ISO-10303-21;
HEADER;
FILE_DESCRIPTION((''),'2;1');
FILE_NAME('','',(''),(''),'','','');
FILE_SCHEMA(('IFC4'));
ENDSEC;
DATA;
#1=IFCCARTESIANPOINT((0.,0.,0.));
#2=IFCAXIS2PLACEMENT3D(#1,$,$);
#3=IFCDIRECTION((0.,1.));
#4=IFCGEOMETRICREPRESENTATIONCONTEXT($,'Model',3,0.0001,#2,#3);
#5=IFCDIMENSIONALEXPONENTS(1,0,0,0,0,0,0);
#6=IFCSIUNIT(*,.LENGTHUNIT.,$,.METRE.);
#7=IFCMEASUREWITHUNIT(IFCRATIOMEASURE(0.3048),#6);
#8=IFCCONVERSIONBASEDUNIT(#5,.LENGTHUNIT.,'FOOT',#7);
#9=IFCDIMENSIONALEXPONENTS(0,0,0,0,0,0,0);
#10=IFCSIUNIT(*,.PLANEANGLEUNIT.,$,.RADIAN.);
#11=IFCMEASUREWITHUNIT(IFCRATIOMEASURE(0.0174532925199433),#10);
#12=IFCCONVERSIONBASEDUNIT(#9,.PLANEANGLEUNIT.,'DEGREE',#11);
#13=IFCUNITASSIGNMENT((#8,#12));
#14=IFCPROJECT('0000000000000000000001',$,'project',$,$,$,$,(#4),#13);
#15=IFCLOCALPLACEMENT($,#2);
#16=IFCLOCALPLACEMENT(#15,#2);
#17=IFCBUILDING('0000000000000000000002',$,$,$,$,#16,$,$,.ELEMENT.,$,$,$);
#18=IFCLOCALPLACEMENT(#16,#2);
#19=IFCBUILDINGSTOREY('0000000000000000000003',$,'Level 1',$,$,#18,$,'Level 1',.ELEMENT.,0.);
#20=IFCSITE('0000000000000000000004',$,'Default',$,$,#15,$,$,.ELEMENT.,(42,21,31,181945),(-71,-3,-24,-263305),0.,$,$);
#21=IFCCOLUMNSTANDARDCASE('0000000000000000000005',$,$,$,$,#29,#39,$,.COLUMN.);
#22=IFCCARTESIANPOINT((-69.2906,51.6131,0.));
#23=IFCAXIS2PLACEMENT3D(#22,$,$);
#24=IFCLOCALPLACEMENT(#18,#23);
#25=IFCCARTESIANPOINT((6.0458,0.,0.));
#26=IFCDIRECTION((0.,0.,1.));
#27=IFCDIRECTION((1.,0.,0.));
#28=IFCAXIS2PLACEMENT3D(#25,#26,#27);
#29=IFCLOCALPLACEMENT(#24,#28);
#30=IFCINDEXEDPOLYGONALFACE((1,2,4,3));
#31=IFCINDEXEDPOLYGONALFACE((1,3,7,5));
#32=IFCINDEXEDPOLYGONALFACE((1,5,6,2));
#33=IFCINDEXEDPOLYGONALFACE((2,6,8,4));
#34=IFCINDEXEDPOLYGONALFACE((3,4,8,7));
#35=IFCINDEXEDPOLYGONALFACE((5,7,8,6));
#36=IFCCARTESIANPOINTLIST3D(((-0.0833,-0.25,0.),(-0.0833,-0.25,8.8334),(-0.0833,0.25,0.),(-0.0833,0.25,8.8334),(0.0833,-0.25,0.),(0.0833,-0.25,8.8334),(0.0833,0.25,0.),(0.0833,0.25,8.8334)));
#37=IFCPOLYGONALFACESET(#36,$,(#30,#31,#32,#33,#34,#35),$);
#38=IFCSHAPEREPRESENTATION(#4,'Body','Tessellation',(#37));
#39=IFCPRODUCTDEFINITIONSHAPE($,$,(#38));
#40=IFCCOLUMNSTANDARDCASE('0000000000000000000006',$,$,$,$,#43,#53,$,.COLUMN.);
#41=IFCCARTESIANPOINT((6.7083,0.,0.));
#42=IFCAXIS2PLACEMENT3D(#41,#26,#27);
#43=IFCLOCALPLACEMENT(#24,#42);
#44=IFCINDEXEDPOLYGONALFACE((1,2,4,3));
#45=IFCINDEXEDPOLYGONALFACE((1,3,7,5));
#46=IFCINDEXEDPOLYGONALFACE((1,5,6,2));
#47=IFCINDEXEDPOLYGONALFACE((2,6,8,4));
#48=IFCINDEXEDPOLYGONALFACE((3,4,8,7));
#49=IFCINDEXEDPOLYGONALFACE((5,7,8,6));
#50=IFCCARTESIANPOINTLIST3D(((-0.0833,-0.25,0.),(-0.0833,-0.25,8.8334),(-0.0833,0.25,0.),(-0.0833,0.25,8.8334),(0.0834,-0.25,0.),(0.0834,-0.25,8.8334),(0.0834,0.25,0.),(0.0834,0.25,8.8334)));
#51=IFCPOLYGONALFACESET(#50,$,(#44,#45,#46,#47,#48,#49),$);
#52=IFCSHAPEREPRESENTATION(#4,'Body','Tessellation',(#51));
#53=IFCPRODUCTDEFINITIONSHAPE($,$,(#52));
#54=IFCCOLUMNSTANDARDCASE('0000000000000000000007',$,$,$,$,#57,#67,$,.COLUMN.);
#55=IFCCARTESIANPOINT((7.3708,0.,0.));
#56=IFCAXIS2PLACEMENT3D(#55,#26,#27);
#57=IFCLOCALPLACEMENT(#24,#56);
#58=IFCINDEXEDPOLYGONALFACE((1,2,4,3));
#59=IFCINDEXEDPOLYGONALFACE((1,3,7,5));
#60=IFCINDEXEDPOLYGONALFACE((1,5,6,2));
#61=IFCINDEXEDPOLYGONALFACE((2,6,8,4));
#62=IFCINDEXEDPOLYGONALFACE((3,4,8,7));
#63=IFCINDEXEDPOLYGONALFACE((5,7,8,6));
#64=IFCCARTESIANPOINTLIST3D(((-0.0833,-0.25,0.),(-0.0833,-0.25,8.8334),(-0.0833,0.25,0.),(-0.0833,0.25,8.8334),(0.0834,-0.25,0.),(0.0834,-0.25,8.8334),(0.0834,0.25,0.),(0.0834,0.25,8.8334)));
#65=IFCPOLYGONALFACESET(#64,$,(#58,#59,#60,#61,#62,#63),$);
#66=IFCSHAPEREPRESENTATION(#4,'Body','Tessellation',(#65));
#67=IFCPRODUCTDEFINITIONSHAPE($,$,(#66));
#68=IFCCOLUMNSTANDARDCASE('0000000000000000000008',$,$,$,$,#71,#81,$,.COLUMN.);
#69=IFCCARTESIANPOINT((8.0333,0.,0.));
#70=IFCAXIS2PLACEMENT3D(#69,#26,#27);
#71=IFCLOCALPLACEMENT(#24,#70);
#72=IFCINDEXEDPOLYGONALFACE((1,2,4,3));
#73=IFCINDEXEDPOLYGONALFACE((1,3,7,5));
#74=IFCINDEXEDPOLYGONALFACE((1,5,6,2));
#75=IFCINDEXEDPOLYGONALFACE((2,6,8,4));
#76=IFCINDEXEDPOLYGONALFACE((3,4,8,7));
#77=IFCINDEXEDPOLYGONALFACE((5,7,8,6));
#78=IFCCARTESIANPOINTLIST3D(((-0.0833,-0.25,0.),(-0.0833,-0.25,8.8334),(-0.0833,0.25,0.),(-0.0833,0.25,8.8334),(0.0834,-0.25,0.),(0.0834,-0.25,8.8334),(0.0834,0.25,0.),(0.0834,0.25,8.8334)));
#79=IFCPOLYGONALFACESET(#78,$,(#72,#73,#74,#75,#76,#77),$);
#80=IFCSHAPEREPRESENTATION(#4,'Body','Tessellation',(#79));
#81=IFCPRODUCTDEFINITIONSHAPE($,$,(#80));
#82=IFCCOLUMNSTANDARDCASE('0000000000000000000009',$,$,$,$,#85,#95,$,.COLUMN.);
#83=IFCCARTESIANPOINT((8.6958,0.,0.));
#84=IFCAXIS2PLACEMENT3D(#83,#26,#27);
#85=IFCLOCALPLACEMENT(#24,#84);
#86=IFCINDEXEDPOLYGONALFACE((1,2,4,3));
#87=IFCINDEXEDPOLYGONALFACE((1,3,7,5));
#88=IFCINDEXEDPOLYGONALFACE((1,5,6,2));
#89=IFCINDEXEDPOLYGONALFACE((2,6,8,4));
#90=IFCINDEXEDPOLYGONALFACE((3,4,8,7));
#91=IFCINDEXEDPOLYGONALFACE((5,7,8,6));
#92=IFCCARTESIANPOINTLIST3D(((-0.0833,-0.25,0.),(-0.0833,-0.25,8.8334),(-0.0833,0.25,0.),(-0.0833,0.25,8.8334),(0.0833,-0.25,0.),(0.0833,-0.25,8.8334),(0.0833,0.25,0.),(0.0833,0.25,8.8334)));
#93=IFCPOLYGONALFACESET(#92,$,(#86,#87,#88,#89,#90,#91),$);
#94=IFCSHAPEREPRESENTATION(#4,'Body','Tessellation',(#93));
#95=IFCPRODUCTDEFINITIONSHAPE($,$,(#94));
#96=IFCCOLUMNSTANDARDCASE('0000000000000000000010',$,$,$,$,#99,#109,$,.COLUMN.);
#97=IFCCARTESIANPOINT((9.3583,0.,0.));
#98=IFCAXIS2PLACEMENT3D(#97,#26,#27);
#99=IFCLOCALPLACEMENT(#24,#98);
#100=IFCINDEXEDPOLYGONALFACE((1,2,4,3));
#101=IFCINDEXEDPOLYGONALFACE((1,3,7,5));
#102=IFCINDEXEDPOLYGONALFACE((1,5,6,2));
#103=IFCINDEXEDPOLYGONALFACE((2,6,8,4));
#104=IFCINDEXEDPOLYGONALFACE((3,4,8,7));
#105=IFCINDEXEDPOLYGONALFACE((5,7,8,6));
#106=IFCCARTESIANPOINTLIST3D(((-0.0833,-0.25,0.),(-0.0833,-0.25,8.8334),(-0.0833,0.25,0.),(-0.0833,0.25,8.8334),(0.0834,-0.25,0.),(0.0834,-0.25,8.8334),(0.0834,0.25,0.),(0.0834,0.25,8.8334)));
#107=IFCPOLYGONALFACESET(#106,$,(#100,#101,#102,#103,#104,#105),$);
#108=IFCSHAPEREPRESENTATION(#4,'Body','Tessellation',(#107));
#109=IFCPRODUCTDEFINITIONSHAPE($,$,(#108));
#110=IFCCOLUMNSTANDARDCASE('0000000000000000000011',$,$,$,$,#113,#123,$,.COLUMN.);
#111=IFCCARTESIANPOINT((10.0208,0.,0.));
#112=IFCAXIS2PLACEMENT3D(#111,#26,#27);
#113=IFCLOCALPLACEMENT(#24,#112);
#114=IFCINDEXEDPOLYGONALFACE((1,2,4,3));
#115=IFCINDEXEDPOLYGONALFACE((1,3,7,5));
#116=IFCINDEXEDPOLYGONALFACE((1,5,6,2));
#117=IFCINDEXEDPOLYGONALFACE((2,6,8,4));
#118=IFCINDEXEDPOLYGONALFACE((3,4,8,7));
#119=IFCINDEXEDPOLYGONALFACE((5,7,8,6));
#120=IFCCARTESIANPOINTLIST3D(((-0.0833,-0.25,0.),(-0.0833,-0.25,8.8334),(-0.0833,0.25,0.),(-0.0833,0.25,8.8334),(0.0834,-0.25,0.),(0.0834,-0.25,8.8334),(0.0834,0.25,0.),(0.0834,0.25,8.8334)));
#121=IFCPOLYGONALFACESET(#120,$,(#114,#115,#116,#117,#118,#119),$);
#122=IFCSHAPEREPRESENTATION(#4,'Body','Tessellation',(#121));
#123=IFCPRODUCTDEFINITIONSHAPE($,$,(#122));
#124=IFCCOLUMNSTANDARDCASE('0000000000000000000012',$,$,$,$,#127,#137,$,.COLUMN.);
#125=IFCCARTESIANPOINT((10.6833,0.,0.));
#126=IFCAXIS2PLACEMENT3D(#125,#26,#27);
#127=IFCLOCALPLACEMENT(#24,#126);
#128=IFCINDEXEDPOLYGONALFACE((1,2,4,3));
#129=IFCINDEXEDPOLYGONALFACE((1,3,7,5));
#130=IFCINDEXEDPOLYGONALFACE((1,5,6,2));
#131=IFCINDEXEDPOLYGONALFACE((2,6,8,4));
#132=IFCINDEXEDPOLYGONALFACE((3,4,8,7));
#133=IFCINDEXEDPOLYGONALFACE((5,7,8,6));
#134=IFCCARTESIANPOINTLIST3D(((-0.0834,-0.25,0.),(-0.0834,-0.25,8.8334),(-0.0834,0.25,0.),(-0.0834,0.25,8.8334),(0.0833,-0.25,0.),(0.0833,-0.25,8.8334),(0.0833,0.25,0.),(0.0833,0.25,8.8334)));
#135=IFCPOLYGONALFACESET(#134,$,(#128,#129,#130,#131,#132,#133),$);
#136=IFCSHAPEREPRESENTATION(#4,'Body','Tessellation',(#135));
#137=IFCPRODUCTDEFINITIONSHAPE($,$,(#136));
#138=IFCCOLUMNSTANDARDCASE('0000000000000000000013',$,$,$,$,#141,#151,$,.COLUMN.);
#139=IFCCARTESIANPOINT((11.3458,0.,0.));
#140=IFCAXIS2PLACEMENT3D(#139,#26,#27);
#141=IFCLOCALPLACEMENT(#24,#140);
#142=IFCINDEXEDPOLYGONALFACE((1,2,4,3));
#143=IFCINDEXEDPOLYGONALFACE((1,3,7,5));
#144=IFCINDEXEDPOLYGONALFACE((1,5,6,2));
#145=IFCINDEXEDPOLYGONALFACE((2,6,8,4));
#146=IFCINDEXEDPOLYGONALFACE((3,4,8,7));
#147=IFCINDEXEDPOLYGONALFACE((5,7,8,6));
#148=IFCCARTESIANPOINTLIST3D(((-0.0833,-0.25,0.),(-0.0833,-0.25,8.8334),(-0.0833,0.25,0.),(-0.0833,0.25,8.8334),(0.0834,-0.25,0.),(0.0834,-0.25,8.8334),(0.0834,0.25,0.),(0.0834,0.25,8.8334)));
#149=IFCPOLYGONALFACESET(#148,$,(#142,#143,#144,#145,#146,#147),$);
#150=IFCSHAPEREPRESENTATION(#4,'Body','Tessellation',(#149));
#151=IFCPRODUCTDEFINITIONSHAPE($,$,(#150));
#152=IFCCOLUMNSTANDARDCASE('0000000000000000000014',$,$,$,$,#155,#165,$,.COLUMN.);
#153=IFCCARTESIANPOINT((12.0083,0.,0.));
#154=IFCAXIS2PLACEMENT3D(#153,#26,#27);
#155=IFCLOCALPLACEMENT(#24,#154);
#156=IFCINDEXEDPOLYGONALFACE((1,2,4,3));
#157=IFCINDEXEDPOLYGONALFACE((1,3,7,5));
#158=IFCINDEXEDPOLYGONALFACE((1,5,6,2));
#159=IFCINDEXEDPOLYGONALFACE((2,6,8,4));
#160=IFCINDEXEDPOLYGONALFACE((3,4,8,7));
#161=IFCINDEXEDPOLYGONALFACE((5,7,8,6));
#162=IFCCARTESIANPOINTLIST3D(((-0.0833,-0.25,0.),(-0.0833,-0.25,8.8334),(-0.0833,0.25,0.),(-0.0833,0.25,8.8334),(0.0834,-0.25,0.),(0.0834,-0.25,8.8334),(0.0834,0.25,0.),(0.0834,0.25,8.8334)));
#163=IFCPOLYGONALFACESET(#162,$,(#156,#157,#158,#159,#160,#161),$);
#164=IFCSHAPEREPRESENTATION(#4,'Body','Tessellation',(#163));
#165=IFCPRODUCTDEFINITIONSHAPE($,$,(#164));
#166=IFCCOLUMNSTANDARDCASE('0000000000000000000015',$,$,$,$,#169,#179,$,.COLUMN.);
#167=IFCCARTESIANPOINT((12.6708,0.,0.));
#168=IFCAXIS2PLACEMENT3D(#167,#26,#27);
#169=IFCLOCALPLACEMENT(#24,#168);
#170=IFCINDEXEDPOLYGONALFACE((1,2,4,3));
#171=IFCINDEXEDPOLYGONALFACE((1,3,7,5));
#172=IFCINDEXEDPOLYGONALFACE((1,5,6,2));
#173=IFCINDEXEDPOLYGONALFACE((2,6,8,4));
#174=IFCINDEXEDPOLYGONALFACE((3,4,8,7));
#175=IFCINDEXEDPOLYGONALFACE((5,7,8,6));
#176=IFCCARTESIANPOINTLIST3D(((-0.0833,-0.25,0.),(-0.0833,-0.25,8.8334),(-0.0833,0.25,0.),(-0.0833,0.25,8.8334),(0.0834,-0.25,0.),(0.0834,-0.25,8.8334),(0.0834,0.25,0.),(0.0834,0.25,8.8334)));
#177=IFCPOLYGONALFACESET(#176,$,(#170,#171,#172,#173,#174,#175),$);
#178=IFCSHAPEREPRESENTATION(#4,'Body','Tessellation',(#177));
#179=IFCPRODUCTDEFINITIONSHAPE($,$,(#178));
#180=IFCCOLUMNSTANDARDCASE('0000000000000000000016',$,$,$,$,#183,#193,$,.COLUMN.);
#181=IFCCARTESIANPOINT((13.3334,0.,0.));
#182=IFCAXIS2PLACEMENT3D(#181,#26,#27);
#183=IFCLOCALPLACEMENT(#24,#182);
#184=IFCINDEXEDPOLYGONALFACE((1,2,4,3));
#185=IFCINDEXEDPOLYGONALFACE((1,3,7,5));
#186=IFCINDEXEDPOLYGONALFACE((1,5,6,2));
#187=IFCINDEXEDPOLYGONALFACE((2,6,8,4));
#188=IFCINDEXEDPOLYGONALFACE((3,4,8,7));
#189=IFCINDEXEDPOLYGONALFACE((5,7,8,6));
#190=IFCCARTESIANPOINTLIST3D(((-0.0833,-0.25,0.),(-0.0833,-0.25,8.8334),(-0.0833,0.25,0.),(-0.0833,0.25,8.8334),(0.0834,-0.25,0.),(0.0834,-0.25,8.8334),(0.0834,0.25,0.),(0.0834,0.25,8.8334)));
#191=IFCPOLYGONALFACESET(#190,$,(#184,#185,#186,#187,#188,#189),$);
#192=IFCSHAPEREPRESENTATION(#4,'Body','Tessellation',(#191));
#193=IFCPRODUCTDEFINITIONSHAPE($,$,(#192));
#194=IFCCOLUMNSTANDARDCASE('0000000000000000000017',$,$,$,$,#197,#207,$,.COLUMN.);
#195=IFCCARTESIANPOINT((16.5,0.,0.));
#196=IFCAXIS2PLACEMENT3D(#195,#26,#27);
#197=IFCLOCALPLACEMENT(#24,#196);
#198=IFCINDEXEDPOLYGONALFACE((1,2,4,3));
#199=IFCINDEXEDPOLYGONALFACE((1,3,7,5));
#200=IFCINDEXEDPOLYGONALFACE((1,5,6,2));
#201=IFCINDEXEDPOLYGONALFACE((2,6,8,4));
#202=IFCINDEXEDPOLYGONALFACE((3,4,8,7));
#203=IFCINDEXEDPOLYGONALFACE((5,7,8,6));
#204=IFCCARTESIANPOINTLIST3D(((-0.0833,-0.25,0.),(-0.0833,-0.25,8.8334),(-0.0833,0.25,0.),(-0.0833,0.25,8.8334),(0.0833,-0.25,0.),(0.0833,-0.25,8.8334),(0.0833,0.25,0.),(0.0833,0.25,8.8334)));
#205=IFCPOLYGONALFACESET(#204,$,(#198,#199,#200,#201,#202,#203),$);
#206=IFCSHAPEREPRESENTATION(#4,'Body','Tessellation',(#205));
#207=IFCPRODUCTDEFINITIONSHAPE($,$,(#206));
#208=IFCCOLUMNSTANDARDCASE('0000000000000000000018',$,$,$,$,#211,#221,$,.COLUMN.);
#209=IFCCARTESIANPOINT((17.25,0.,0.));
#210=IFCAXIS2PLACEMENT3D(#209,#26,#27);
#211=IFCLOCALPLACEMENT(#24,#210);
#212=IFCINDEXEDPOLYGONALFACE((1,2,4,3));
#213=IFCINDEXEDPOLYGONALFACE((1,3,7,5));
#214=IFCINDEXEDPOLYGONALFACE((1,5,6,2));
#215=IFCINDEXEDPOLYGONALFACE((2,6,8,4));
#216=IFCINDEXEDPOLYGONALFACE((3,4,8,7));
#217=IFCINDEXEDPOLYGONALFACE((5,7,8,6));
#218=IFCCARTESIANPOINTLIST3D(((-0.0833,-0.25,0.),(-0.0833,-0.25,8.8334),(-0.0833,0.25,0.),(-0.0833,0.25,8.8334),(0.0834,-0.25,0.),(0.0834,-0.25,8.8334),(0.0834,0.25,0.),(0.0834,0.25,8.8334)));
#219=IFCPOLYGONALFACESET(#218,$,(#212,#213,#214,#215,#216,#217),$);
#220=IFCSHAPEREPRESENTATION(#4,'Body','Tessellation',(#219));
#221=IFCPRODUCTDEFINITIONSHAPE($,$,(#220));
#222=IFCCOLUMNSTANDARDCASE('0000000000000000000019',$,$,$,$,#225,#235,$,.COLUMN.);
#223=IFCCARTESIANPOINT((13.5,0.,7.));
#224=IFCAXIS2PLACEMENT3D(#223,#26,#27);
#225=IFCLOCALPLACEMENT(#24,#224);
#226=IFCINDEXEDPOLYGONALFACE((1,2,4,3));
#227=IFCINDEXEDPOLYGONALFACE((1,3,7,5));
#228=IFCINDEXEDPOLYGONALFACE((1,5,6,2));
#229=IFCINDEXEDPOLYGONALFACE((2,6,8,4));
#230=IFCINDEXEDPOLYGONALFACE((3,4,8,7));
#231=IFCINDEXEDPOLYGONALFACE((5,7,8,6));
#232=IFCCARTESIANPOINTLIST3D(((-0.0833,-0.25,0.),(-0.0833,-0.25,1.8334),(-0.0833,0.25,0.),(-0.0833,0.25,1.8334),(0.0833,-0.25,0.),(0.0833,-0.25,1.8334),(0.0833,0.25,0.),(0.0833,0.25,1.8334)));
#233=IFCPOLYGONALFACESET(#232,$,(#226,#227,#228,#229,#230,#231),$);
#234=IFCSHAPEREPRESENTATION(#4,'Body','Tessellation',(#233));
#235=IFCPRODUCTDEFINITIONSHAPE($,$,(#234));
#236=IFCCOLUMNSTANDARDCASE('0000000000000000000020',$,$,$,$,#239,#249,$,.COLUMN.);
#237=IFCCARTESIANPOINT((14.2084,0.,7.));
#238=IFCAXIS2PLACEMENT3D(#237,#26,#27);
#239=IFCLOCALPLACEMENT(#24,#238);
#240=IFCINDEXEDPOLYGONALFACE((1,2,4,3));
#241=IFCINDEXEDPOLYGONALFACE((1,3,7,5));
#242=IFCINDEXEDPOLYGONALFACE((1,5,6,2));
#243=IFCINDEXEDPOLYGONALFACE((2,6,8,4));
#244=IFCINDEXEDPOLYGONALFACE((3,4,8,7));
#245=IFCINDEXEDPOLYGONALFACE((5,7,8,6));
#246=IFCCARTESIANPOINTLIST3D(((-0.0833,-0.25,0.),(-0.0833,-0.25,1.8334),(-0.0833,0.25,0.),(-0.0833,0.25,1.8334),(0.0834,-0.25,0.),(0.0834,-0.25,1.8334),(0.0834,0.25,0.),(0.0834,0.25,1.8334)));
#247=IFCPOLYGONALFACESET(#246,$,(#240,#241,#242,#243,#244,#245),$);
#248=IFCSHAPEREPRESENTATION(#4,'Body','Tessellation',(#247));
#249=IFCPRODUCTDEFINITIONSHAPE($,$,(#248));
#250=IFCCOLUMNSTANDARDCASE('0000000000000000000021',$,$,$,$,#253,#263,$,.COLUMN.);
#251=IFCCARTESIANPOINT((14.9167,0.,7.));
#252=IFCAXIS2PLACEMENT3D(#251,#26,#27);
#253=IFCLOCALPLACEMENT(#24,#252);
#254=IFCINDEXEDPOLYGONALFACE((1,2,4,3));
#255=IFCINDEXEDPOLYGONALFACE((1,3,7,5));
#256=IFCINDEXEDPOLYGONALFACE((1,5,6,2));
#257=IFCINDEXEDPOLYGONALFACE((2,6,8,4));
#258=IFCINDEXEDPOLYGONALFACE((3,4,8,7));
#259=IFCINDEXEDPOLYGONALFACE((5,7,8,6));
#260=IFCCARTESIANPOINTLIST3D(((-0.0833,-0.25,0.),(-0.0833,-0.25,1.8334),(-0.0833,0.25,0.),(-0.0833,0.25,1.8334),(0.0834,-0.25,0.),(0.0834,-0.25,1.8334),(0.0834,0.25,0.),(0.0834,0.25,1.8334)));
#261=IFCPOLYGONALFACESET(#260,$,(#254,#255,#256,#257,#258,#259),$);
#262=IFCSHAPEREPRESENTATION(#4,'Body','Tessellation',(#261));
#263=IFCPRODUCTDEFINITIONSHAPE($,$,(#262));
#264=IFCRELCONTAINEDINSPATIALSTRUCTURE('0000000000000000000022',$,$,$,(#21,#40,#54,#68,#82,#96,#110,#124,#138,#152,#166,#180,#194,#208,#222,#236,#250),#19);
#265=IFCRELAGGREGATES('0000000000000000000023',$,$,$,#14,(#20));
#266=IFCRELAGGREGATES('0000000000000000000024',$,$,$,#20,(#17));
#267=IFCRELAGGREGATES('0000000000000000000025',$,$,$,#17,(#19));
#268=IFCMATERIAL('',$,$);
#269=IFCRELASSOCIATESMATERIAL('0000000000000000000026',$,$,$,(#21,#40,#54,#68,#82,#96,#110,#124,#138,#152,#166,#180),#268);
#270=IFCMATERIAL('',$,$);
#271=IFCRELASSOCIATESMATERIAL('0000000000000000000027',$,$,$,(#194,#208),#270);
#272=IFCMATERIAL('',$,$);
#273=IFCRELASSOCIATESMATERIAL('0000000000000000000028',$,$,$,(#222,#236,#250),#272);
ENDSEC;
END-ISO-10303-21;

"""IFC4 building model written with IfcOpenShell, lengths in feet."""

from ifc_helpers import new_model, entity, si_unit, converted_unit, direction, frame, origin, place, context, project, spatial, rectangle, extrude, material, element, save


model = new_model("IFC4")

# Units and contexts
model_context = context("Model", 3, precision=0.0001, world=origin(), true_north=direction((0.0, 1.0)))
ifc_project = project(units=[converted_unit("LENGTHUNIT", "FOOT", entity("IfcRatioMeasure", 0.3048), si_unit("LENGTHUNIT", "METRE"), dimensions=[1, 0, 0, 0, 0, 0, 0]), converted_unit("PLANEANGLEUNIT", "DEGREE", entity("IfcRatioMeasure", 0.0174532925199433), si_unit("PLANEANGLEUNIT", "RADIAN"), dimensions=[0, 0, 0, 0, 0, 0, 0])], contexts=[model_context])

# Site, building, storey
site_placement = place(None, origin())
site = spatial("IfcSite", under=ifc_project, at=site_placement, Name="Default", CompositionType="ELEMENT", RefLatitude=(42, 21, 31, 181945), RefLongitude=(-71, -3, -24, -263305), RefElevation=0.0)
building_placement = place(site_placement, origin())
building = spatial("IfcBuilding", under=site, at=building_placement, CompositionType="ELEMENT")
storey_placement = place(building_placement, origin())
storey = spatial("IfcBuildingStorey", under=building, at=storey_placement, Name="Level 1", LongName="Level 1", CompositionType="ELEMENT", Elevation=0.0)

# Columns
ifc_material_1 = material(Name="")
ifc_material_2 = material(Name="")
placement_1 = place(storey_placement, frame((-69.2906, 51.6131, 0.0)))
for number, where, z_axis, x_axis in (
    (1, (6.0458, 0.0, 0.0), (0.0, 0.0, 1.0), (1.0, 0.0, 0.0)),
    (2, (6.7083, 0.0, 0.0), (0.0, 0.0, 1.0), (1.0, 0.0, 0.0)),
    (3, (7.3708, 0.0, 0.0), (0.0, 0.0, 1.0), (1.0, 0.0, 0.0)),
    (4, (8.0333, 0.0, 0.0), (0.0, 0.0, 1.0), (1.0, 0.0, 0.0)),
    (5, (8.6958, 0.0, 0.0), (0.0, 0.0, 1.0), (1.0, 0.0, 0.0)),
    (6, (9.3583, 0.0, 0.0), (0.0, 0.0, 1.0), (1.0, 0.0, 0.0)),
    (7, (10.0208, 0.0, 0.0), (0.0, 0.0, 1.0), (1.0, 0.0, 0.0)),
    (8, (10.6833, 0.0, 0.0), (0.0, 0.0, 1.0), (1.0, 0.0, 0.0)),
    (9, (11.3458, 0.0, 0.0), (0.0, 0.0, 1.0), (1.0, 0.0, 0.0)),
    (10, (12.0083, 0.0, 0.0), (0.0, 0.0, 1.0), (1.0, 0.0, 0.0)),
    (11, (12.6708, 0.0, 0.0), (0.0, 0.0, 1.0), (1.0, 0.0, 0.0)),
    (12, (13.3334, 0.0, 0.0), (0.0, 0.0, 1.0), (1.0, 0.0, 0.0)),
):
    element("IfcColumnStandardCase", number, at=place(placement_1, frame(where, z_axis=z_axis, x_axis=x_axis)), inside=storey, material=ifc_material_2, PredefinedType="COLUMN", context=model_context, shape_type="SweptSolid", body=[
        extrude(rectangle(XDim=0.1667, YDim=0.5), origin(), (0.0, 0.0, 1.0), 8.8334),
    ])
for number, where, z_axis, x_axis in (
    (13, (16.5, 0.0, 0.0), (0.0, 0.0, 1.0), (1.0, 0.0, 0.0)),
    (14, (17.25, 0.0, 0.0), (0.0, 0.0, 1.0), (1.0, 0.0, 0.0)),
):
    element("IfcColumnStandardCase", number, at=place(placement_1, frame(where, z_axis=z_axis, x_axis=x_axis)), inside=storey, material=ifc_material_1, PredefinedType="COLUMN", context=model_context, shape_type="SweptSolid", body=[
        extrude(rectangle(XDim=0.1667, YDim=0.5), origin(), (0.0, 0.0, 1.0), 8.8334),
    ])
ifc_material_3 = material(Name="")
for number, where, z_axis, x_axis in (
    (15, (13.5, 0.0, 7.0), (0.0, 0.0, 1.0), (1.0, 0.0, 0.0)),
    (16, (14.2084, 0.0, 7.0), (0.0, 0.0, 1.0), (1.0, 0.0, 0.0)),
    (17, (14.9167, 0.0, 7.0), (0.0, 0.0, 1.0), (1.0, 0.0, 0.0)),
):
    element("IfcColumnStandardCase", number, at=place(placement_1, frame(where, z_axis=z_axis, x_axis=x_axis)), inside=storey, material=ifc_material_3, PredefinedType="COLUMN", context=model_context, shape_type="SweptSolid", body=[
        extrude(rectangle(XDim=0.1667, YDim=0.5), origin(), (0.0, 0.0, 1.0), 1.8334),
    ])

save(model, "model.ifc")
